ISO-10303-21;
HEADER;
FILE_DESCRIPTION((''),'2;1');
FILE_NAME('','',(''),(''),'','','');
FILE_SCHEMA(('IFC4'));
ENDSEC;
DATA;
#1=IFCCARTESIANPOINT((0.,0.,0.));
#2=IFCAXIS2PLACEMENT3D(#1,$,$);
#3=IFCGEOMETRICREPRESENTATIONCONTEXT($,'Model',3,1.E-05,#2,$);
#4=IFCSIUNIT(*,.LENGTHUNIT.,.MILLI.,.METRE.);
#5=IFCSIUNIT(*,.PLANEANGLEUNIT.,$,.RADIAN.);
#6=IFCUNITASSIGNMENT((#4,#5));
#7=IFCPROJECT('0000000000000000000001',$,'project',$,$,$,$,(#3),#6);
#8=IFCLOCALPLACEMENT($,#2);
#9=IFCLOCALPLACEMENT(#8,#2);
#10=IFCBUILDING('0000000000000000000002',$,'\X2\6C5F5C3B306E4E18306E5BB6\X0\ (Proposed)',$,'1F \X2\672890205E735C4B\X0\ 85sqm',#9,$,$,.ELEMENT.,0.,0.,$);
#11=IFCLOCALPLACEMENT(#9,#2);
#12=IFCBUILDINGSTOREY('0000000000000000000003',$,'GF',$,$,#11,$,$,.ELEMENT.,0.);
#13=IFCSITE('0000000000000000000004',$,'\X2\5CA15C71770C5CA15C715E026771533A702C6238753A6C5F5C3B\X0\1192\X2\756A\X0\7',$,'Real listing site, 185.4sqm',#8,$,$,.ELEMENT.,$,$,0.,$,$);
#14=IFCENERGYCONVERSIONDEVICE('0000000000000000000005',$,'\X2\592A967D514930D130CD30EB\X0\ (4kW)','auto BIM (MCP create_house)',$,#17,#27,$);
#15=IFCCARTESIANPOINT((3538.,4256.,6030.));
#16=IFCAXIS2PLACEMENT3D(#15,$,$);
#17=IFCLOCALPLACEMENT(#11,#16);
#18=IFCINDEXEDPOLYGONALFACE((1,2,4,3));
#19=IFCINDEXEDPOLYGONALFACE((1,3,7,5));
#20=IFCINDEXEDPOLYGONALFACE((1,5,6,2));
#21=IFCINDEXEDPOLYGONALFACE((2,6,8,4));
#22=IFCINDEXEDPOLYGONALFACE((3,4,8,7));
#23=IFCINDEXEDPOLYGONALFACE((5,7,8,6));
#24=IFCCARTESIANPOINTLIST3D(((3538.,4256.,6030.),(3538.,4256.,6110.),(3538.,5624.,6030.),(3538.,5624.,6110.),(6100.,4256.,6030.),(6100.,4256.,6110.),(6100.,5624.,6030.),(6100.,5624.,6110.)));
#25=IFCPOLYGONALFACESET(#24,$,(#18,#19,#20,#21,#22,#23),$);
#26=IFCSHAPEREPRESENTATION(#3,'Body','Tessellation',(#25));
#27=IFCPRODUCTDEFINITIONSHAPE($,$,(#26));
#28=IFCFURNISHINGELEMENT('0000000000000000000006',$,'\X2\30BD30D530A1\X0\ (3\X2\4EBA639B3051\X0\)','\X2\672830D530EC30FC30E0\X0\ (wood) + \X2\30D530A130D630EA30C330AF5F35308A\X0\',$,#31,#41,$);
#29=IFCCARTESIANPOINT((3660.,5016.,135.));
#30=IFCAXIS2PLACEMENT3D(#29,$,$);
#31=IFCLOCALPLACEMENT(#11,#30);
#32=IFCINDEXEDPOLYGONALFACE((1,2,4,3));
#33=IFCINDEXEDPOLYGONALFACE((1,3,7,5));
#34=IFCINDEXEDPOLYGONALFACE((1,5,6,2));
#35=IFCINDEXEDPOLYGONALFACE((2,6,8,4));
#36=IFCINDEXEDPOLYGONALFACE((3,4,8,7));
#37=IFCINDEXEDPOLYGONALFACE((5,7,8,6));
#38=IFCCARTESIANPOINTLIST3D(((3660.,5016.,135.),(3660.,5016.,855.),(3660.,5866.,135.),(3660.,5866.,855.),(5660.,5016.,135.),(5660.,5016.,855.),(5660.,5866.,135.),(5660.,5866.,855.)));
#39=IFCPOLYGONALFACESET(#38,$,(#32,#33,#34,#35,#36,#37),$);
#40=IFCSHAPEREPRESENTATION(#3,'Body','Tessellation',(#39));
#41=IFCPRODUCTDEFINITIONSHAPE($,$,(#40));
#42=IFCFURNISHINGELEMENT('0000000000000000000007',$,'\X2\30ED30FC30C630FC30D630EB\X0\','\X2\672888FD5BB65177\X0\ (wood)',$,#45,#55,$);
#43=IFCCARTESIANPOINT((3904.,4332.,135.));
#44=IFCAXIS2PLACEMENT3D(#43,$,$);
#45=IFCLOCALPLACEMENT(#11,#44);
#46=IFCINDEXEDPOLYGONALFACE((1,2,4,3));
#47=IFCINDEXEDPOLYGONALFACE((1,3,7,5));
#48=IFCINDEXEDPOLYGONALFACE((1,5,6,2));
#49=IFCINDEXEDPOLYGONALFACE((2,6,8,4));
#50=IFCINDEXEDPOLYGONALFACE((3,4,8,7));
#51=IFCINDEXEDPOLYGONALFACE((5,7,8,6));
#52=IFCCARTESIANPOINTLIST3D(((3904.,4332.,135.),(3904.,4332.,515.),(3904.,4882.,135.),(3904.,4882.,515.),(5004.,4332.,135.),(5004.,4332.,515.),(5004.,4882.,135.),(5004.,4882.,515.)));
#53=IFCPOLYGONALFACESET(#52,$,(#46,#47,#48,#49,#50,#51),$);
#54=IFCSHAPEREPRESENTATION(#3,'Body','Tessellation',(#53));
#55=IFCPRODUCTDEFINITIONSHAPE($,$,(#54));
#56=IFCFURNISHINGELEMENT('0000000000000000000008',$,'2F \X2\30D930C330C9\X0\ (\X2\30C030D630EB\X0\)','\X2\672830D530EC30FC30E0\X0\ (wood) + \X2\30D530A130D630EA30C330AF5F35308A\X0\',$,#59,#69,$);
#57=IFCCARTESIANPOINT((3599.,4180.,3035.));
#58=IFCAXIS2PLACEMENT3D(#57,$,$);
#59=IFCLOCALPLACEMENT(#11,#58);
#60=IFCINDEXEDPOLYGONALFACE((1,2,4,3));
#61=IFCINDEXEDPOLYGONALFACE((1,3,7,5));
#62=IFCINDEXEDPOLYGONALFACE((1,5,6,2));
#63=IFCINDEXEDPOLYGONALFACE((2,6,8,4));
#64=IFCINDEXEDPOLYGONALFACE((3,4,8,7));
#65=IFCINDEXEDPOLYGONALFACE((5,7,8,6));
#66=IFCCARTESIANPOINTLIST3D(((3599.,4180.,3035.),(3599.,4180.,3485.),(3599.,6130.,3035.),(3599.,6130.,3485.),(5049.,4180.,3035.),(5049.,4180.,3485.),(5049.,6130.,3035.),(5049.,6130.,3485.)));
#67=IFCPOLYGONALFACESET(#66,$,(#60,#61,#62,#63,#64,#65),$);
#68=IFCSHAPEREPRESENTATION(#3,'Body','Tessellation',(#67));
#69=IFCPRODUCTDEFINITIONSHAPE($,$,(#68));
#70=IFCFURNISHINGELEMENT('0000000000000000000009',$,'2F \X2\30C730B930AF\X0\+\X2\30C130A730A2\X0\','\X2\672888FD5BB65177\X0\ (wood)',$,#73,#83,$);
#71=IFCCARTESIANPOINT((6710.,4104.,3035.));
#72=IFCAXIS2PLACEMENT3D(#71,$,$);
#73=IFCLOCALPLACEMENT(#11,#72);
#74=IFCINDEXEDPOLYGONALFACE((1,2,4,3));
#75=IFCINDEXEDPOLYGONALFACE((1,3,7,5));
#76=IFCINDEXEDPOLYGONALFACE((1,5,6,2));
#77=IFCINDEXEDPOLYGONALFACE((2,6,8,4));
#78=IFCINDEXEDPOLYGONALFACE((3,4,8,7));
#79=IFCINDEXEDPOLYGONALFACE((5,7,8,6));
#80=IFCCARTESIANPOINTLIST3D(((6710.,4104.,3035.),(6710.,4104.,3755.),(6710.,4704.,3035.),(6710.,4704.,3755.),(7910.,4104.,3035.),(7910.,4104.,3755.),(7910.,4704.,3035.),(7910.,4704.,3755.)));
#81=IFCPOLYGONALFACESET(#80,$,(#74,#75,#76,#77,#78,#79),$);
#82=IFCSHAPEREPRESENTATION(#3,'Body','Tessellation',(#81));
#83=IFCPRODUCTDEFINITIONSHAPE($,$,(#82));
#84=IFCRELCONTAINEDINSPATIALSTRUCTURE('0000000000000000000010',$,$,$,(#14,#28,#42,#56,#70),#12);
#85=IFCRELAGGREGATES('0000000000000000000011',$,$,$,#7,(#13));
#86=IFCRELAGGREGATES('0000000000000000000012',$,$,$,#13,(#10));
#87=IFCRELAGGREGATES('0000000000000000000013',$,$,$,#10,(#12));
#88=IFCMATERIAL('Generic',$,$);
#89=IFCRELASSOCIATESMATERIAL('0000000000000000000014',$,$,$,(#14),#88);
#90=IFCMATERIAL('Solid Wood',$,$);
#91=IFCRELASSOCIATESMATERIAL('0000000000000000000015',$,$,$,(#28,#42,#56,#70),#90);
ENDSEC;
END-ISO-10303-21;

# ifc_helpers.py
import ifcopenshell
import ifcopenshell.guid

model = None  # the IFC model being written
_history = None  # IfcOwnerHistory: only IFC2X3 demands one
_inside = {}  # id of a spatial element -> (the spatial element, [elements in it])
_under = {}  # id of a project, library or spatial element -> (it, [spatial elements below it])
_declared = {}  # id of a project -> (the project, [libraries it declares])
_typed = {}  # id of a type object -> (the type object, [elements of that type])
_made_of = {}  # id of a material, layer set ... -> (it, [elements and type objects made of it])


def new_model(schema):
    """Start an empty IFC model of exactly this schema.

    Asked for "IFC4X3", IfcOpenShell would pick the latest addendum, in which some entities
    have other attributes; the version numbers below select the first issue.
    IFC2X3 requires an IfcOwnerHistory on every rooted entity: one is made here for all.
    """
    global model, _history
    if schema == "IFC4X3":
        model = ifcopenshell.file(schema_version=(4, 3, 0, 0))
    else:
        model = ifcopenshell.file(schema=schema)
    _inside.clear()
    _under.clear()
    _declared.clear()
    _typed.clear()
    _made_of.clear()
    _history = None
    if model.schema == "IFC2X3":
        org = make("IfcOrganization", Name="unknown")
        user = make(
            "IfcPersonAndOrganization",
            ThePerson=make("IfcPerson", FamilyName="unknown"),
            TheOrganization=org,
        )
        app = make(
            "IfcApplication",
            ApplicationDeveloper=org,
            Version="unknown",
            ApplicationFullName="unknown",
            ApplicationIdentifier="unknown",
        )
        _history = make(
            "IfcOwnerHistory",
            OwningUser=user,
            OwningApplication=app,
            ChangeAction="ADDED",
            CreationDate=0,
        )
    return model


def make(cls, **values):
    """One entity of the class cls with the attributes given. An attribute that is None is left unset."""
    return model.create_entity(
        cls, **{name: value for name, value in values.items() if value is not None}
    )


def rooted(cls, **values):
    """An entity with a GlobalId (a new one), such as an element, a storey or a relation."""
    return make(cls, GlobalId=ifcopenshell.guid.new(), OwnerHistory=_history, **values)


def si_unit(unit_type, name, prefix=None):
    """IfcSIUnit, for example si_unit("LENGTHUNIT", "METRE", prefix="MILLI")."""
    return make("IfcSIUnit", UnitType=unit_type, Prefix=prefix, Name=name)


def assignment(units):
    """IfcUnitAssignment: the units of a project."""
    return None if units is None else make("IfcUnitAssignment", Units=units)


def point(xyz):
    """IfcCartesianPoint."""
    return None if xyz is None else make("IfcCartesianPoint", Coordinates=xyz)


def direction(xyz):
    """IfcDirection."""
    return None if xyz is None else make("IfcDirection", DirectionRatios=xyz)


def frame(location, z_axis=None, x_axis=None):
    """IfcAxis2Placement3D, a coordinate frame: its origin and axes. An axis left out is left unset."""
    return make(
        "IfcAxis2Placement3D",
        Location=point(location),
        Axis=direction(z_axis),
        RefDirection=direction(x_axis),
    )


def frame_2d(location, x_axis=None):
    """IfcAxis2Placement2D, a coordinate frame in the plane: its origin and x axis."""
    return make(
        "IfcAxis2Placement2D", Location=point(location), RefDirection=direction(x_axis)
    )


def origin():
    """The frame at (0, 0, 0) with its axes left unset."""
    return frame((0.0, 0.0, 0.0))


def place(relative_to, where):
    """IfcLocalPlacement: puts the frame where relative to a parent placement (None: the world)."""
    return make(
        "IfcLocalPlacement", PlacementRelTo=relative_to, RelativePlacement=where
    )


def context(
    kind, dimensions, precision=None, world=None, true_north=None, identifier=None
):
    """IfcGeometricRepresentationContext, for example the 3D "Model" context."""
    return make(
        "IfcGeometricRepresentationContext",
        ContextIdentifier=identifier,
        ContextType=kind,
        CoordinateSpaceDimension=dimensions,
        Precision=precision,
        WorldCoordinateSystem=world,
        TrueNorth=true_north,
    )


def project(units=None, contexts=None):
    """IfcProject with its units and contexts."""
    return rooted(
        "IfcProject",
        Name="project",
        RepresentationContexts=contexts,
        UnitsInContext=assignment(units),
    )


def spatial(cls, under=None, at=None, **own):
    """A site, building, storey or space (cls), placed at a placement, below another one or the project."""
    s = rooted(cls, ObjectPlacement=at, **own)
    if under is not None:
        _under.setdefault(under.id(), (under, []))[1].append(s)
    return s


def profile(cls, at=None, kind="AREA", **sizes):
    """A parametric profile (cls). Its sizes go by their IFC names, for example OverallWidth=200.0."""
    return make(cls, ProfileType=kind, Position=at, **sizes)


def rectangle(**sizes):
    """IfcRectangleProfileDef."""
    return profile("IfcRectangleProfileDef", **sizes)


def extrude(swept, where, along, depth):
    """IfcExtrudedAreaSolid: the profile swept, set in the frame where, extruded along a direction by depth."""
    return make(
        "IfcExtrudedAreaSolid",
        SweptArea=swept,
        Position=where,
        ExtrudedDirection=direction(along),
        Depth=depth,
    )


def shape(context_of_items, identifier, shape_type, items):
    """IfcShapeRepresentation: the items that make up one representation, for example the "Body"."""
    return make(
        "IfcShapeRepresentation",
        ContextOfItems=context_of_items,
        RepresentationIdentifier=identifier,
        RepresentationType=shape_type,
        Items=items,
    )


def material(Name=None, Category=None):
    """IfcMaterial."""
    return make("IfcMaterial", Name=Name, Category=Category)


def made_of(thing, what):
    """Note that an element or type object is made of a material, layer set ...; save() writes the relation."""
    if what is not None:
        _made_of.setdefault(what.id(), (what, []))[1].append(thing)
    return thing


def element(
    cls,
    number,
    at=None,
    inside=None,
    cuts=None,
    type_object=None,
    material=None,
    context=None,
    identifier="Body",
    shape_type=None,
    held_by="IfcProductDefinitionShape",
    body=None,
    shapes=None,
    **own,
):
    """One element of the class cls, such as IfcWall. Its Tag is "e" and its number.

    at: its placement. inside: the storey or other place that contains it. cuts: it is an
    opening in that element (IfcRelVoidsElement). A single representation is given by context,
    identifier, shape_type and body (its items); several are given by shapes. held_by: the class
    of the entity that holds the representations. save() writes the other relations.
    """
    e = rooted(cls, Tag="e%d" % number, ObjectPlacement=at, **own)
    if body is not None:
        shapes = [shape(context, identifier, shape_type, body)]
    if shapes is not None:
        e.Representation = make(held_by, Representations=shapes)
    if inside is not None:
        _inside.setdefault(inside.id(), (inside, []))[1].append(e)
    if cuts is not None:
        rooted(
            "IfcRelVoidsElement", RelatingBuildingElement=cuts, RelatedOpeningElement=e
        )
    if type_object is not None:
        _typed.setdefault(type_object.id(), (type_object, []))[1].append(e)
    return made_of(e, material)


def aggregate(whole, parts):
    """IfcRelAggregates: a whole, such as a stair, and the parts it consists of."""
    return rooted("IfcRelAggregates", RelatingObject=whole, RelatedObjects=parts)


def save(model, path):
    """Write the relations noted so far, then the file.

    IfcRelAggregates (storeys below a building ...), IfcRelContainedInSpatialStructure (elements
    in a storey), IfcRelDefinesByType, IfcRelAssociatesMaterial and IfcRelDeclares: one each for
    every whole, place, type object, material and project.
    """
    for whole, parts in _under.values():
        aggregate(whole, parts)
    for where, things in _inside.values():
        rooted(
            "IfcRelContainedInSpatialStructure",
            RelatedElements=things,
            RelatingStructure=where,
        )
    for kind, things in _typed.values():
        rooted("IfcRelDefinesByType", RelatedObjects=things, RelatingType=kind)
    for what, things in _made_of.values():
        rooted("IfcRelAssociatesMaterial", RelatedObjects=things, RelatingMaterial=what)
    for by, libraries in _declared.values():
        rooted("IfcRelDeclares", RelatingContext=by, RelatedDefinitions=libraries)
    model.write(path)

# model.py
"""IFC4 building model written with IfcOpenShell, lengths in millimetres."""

from ifc_helpers import new_model, si_unit, frame, frame_2d, origin, place, context, project, spatial, rectangle, extrude, material, element, save


model = new_model("IFC4")

# Units and contexts
model_context = context("Model", 3, precision=1e-05, world=origin())
ifc_project = project(units=[si_unit("LENGTHUNIT", "METRE", prefix="MILLI"), si_unit("PLANEANGLEUNIT", "RADIAN")], contexts=[model_context])

# Site, building, storey
site_placement = place(None, origin())
site = spatial("IfcSite", under=ifc_project, at=site_placement, Name="岡山県岡山市東区瀬戸町江尻1192番7", ObjectType="Real listing site, 185.4sqm", CompositionType="ELEMENT", RefElevation=0.0)
building_placement = place(site_placement, origin())
building = spatial("IfcBuilding", under=site, at=building_placement, Name="江尻の丘の家 (Proposed)", ObjectType="1F 木造平屋 85sqm", CompositionType="ELEMENT", ElevationOfRefHeight=0.0, ElevationOfTerrain=0.0)
storey_placement = place(building_placement, origin())
storey = spatial("IfcBuildingStorey", under=building, at=storey_placement, Name="GF", CompositionType="ELEMENT", Elevation=0.0)

# Shared definitions
ifc_material_1 = material(Name="Solid Wood")

# Shared definitions
ifc_material_2 = material(Name="Generic")

# Energy conversion device
energy_conversion_device_placement = place(storey_placement, frame((3538.0, 4256.0, 6030.0)))
element("IfcEnergyConversionDevice", 1, at=energy_conversion_device_placement, inside=storey, material=ifc_material_2, Name="太陽光パネル (4kW)", Description="auto BIM (MCP create_house)", context=model_context, shape_type="SweptSolid", body=[
    extrude(rectangle(XDim=2562.0, YDim=1368.0, at=frame_2d((1281.0, 684.0))), frame((3538.0, 4256.0, 6030.0)), (0.0, 0.0, 1.0), 80.0),
])

# Furnishing elements
furnishing_1_placement = place(storey_placement, frame((3660.0, 5016.0, 135.0)))
element("IfcFurnishingElement", 2, at=furnishing_1_placement, inside=storey, material=ifc_material_1, Name="ソファ (3人掛け)", Description="木フレーム (wood) + ファブリック張り", context=model_context, shape_type="SweptSolid", body=[
    extrude(rectangle(XDim=2000.0, YDim=850.0, at=frame_2d((1000.0, 425.0))), frame((3660.0, 5016.0, 135.0)), (0.0, 0.0, 1.0), 720.0),
])
furnishing_2_placement = place(storey_placement, frame((3904.0, 4332.0, 135.0)))
element("IfcFurnishingElement", 3, at=furnishing_2_placement, inside=storey, material=ifc_material_1, Name="ローテーブル", Description="木製家具 (wood)", context=model_context, shape_type="SweptSolid", body=[
    extrude(rectangle(XDim=1100.0, YDim=550.0, at=frame_2d((550.0, 275.0))), frame((3904.0, 4332.0, 135.0)), (0.0, 0.0, 1.0), 380.0),
])
furnishing_3_placement = place(storey_placement, frame((3599.0, 4180.0, 3035.0)))
element("IfcFurnishingElement", 4, at=furnishing_3_placement, inside=storey, material=ifc_material_1, Name="2F ベッド (ダブル)", Description="木フレーム (wood) + ファブリック張り", context=model_context, shape_type="SweptSolid", body=[
    extrude(rectangle(XDim=1450.0, YDim=1950.0, at=frame_2d((725.0, 975.0))), frame((3599.0, 4180.0, 3035.0)), (0.0, 0.0, 1.0), 450.0),
])
furnishing_4_placement = place(storey_placement, frame((6710.0, 4104.0, 3035.0)))
element("IfcFurnishingElement", 5, at=furnishing_4_placement, inside=storey, material=ifc_material_1, Name="2F デスク+チェア", Description="木製家具 (wood)", context=model_context, shape_type="SweptSolid", body=[
    extrude(rectangle(XDim=1200.0, YDim=600.0, at=frame_2d((600.0, 300.0))), frame((6710.0, 4104.0, 3035.0)), (0.0, 0.0, 1.0), 720.0),
])

save(model, "model.ifc")
